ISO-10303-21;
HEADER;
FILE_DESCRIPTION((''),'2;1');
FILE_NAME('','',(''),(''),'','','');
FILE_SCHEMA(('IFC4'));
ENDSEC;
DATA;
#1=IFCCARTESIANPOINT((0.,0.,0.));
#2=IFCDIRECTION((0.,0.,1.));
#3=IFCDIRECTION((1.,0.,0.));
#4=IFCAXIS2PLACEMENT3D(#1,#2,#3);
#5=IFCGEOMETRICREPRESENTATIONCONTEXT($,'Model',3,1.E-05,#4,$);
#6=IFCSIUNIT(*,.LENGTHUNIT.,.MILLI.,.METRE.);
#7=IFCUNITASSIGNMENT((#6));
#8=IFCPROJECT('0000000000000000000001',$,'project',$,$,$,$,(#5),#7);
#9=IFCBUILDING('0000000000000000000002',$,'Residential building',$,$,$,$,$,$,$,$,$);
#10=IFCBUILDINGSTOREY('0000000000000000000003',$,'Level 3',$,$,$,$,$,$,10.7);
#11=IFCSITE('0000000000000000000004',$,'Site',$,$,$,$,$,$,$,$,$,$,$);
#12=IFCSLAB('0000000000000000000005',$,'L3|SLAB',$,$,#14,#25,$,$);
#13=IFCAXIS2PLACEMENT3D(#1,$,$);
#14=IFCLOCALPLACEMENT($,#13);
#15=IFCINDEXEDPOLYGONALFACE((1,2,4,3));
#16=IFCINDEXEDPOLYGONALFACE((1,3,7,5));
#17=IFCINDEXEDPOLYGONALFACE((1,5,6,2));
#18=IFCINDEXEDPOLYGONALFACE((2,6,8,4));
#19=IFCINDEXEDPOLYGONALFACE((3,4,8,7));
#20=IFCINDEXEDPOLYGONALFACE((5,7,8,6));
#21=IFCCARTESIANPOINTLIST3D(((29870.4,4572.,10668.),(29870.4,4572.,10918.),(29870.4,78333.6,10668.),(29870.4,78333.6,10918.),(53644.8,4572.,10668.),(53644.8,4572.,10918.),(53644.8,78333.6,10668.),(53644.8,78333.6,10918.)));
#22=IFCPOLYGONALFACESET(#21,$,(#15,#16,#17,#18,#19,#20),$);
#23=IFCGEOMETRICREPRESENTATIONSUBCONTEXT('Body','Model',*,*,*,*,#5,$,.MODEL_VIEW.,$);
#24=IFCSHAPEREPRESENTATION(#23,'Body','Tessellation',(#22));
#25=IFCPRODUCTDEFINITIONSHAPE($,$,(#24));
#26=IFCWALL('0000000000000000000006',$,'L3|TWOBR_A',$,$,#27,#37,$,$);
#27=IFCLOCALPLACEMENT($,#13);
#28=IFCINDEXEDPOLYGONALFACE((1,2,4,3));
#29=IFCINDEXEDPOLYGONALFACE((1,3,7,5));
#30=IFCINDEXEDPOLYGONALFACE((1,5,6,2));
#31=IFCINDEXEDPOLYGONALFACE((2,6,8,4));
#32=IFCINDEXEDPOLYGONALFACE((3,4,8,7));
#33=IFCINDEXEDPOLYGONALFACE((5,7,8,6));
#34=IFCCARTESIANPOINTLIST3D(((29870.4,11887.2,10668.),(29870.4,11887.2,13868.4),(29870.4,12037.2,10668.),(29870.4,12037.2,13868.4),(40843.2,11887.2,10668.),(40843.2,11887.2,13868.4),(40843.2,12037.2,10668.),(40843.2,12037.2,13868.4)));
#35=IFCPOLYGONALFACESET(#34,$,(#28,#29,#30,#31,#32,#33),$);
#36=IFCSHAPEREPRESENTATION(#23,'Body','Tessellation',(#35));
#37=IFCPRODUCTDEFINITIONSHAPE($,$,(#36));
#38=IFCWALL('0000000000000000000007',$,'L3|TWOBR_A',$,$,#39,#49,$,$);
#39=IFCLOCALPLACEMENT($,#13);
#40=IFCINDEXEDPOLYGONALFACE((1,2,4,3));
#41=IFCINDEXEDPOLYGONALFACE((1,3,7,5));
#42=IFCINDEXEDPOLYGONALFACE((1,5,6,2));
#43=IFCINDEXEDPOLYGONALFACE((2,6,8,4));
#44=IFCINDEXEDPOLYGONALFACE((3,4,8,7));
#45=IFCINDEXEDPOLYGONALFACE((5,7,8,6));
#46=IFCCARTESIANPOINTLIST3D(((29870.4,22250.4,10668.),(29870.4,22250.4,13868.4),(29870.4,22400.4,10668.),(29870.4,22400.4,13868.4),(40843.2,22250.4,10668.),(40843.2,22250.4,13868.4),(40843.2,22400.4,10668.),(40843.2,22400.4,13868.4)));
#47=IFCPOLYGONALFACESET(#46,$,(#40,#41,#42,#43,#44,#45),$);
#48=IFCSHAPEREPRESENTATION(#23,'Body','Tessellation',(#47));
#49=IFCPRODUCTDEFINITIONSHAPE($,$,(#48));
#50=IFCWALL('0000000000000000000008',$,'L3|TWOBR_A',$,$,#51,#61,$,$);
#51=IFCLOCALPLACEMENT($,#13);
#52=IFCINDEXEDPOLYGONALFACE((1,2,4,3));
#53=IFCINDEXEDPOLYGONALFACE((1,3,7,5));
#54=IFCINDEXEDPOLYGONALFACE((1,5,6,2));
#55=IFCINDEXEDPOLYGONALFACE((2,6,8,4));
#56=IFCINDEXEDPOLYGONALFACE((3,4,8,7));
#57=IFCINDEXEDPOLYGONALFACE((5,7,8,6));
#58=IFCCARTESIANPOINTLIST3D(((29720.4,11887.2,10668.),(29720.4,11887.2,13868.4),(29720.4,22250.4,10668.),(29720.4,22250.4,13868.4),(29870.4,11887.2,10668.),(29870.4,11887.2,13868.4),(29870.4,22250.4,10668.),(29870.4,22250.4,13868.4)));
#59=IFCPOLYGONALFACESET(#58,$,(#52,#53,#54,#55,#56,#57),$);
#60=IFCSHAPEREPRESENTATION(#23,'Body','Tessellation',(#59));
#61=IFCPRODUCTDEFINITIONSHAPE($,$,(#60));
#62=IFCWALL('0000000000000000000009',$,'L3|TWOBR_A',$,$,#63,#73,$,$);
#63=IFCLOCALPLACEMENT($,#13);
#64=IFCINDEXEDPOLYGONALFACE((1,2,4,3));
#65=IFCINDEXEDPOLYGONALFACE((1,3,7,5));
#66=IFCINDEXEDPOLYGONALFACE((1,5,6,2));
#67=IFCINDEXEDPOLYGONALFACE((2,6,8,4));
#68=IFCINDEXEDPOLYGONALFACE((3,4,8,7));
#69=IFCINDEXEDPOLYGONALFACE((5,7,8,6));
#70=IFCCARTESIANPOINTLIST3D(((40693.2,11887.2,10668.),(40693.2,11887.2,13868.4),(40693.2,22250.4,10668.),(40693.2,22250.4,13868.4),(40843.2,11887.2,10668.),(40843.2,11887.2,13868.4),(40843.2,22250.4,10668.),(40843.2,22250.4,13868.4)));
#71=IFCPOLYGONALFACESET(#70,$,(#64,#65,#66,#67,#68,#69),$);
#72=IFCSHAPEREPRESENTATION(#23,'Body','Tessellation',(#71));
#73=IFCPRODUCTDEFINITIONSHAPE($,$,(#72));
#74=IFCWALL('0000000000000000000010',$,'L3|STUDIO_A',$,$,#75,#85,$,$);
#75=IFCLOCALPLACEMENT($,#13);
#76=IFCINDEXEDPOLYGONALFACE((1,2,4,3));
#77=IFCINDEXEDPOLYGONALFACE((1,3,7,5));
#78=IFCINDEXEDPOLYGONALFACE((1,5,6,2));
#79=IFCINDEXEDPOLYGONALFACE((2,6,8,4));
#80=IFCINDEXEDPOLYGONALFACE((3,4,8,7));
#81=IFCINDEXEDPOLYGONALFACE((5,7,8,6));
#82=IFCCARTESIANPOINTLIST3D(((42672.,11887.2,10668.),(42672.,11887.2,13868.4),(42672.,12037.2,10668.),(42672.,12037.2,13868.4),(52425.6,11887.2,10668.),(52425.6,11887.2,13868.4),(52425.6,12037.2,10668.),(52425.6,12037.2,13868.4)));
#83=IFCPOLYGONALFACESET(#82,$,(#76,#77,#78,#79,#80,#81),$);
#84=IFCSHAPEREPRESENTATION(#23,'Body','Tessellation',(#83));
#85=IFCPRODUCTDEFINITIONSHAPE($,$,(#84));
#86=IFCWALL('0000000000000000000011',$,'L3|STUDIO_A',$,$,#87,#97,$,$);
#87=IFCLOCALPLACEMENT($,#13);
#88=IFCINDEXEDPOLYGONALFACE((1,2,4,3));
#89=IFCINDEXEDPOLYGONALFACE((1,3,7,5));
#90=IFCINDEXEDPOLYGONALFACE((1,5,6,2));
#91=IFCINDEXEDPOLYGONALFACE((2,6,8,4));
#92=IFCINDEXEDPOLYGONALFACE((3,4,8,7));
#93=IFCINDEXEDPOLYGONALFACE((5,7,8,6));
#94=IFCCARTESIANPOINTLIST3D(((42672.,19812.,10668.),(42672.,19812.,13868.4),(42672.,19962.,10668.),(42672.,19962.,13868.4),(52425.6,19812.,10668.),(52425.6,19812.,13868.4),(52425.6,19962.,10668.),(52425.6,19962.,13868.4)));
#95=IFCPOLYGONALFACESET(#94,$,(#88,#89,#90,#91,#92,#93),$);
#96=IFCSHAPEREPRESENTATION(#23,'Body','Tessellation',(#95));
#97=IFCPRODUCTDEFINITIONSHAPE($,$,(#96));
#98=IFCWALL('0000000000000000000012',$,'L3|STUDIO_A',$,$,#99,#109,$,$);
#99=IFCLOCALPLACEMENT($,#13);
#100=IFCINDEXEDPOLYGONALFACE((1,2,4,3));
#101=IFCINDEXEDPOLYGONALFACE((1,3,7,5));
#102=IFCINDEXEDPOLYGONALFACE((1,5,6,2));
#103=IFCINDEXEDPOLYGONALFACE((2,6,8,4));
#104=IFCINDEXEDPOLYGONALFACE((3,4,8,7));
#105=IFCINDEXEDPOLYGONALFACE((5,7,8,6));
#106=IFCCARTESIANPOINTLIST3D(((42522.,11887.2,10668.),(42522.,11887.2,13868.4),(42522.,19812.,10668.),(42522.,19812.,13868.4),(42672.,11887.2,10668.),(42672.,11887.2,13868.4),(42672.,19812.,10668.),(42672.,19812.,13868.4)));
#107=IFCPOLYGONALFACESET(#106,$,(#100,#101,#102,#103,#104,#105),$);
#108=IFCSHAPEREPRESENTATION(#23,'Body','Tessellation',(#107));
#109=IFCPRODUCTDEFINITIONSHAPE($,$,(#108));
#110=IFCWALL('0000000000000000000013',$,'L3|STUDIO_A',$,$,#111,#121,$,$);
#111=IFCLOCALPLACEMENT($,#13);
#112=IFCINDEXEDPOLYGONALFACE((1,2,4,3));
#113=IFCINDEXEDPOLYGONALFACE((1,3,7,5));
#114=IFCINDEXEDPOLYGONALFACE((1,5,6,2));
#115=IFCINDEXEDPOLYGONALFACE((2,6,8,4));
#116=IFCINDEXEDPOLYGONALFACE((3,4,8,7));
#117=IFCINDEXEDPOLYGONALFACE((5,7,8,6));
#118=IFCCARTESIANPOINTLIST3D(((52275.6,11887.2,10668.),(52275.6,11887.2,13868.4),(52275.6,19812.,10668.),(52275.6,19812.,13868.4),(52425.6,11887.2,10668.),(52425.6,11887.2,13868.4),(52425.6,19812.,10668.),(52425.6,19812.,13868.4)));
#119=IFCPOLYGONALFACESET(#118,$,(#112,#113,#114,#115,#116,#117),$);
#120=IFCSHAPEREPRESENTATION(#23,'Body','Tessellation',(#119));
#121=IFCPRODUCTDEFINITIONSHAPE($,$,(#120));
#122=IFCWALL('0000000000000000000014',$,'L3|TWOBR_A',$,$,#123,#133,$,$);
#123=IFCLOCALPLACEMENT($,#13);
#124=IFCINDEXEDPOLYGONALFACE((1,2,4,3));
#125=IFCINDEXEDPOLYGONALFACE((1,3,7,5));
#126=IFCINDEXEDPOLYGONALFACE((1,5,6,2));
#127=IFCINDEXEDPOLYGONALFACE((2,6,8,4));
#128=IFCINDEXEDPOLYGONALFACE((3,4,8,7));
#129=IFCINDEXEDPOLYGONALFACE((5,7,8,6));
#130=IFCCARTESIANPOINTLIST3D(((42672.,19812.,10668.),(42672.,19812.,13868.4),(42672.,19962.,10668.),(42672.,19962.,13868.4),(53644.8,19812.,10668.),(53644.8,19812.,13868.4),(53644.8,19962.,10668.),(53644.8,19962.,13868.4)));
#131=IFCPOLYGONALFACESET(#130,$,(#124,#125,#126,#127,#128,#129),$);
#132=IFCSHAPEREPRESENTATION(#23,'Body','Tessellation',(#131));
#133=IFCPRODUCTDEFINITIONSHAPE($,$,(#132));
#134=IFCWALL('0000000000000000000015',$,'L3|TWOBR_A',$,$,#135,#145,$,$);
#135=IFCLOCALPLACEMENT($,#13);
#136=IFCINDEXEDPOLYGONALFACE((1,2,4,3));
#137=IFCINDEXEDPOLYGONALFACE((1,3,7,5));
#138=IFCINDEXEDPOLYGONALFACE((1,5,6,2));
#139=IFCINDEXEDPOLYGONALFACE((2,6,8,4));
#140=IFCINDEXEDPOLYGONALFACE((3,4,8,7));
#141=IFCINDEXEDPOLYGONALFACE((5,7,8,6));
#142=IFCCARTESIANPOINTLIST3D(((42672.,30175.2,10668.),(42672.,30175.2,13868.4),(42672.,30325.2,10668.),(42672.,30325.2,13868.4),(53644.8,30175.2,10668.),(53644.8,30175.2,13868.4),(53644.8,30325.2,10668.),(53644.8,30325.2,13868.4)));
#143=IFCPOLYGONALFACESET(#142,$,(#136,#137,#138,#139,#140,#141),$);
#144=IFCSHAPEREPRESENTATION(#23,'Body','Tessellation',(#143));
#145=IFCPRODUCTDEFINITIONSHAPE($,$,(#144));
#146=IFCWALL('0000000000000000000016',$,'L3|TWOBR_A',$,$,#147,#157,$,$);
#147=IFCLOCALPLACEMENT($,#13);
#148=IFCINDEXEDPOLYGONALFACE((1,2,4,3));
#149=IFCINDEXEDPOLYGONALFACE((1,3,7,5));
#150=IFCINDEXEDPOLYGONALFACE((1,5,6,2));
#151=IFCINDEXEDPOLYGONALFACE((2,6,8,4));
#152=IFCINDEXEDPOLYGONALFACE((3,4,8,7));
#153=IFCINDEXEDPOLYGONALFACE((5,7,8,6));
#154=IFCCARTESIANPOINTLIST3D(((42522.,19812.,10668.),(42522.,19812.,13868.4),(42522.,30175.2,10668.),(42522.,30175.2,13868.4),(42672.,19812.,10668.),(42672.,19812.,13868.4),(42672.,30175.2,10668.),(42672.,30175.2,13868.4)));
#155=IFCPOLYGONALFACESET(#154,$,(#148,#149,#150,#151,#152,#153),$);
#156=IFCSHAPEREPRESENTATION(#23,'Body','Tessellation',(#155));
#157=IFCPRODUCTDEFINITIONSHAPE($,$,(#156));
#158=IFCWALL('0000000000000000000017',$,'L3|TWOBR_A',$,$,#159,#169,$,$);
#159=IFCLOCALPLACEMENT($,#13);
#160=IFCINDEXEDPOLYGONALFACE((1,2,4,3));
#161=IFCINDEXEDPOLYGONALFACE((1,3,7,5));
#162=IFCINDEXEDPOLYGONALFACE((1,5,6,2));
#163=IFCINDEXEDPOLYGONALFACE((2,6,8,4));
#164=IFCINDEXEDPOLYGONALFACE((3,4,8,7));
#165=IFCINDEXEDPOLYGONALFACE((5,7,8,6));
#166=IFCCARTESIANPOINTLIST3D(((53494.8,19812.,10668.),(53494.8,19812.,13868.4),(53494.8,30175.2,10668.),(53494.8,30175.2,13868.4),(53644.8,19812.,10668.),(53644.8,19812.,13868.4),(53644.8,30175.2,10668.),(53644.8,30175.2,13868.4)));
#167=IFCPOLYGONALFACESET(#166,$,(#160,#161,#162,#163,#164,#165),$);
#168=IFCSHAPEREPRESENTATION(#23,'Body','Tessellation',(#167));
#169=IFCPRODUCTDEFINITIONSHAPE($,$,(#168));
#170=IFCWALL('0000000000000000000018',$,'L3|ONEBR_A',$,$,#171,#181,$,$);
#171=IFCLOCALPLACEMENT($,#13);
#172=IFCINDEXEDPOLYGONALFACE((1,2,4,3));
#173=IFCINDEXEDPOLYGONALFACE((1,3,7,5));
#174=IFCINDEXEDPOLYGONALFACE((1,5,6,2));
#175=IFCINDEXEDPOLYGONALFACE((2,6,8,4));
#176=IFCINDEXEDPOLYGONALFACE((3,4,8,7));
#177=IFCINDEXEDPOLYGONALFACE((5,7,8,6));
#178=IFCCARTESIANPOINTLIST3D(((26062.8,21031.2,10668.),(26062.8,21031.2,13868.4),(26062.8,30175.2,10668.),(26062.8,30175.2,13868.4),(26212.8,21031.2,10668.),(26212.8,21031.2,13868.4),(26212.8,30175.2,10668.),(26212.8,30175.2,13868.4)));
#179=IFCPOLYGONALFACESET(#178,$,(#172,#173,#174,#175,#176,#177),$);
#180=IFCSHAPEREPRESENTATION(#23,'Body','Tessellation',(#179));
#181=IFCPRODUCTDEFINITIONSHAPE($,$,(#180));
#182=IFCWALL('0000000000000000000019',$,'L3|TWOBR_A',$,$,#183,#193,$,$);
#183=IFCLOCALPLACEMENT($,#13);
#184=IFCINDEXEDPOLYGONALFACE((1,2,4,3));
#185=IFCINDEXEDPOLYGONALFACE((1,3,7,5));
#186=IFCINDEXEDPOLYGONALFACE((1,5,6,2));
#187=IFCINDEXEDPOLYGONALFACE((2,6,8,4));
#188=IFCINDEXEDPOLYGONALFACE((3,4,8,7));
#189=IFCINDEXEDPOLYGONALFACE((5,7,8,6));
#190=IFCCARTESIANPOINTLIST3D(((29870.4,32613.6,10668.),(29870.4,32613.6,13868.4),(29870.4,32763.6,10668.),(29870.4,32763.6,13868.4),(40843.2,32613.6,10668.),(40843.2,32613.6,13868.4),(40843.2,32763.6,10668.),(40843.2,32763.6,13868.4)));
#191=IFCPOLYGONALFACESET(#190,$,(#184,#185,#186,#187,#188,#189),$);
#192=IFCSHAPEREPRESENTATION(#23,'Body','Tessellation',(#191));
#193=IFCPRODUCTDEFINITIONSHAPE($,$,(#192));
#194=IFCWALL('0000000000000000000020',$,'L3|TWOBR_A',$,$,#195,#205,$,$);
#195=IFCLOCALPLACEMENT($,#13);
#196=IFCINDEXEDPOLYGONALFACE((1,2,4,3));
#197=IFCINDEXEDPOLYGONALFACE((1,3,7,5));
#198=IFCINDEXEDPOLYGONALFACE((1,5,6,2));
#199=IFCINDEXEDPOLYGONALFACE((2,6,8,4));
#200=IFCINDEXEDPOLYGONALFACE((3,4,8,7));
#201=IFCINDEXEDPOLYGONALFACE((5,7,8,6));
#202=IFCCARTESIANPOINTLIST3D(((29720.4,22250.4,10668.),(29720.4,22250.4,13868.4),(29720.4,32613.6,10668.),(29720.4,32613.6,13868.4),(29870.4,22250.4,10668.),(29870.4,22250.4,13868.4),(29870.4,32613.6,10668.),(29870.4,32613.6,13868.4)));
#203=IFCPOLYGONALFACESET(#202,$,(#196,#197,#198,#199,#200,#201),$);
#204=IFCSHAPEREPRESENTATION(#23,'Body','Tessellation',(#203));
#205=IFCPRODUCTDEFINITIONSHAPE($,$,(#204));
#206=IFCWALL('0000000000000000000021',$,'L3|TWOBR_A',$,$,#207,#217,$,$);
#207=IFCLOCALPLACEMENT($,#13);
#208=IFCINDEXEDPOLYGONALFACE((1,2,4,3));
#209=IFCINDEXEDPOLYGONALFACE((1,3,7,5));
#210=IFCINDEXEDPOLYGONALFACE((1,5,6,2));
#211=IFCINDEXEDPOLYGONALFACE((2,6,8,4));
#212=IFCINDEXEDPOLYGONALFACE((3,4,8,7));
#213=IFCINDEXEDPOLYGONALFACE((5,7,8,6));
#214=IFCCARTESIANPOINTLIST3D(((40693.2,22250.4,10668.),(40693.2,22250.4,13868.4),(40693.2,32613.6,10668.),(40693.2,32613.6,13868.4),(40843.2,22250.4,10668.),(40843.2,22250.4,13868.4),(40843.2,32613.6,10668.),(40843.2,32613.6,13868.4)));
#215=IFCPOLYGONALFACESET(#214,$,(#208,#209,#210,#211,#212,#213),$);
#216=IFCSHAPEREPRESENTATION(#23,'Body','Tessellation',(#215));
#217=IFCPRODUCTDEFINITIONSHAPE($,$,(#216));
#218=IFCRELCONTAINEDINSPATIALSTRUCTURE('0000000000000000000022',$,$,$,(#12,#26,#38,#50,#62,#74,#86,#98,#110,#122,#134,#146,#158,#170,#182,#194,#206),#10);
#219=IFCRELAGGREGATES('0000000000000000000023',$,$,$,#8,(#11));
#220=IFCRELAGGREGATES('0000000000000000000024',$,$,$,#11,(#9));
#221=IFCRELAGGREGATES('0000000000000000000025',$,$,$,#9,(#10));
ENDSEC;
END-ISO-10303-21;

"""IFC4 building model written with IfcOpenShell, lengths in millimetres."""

from ifc_helpers import new_model, si_unit, frame, origin_with_axes, place, context, subcontext, project, spatial, indexed_curve, outline, extrude, element, save


model = new_model("IFC4")

# Units and contexts
model_context = context("Model", 3, precision=1e-05, world=origin_with_axes())
body_context = subcontext(model_context, "Body", "Model", "MODEL_VIEW")
ifc_project = project(units=[si_unit("LENGTHUNIT", "METRE", prefix="MILLI")], contexts=[model_context])

# Site, building, storey
site = spatial("IfcSite", under=ifc_project, Name="Site")
building = spatial("IfcBuilding", under=site, Name="Residential building")
storey = spatial("IfcBuildingStorey", under=building, Name="Level 3", Elevation=10.7)

# Slab
slab_placement = place(None, frame((29870.4, 4572.0, 10668.0), z_axis=(0.0, 0.0, 1.0), x_axis=(1.0, 0.0, 0.0)))
element("IfcSlab", 1, at=slab_placement, inside=storey, Name="L3|SLAB", context=body_context, shape_type="SweptSolid", body=[
    extrude(outline(indexed_curve([(0.0, 0.0), (23774.4, 0.0), (23774.4, 73761.6), (0.0, 73761.6), (0.0, 0.0)])), None, (0.0, 0.0, 1.0), 250.0),
])

# Walls
for number, where, z_axis, x_axis, name in (
    (2, (29870.4, 11887.2, 10668.0), (0.0, 0.0, 1.0), (1.0, 0.0, 0.0), "L3|TWOBR_A"),
    (3, (29870.4, 22250.4, 10668.0), (0.0, 0.0, 1.0), (1.0, 0.0, 0.0), "L3|TWOBR_A"),
):
    element("IfcWall", number, at=place(None, frame(where, z_axis=z_axis, x_axis=x_axis)), inside=storey, Name=name, context=body_context, shape_type="SweptSolid", body=[
        extrude(outline(indexed_curve([(0.0, 0.0), (0.0, 150.0), (10972.8, 150.0), (10972.8, 0.0), (0.0, 0.0)], self_intersect=False)), origin_with_axes(), (0.0, 0.0, 1.0), 3200.4),
    ])
for number, where, z_axis, x_axis, name in (
    (4, (29870.4, 11887.2, 10668.0), (0.0, 0.0, 1.0), (0.0, 1.0, 0.0), "L3|TWOBR_A"),
    (5, (40843.2, 11887.2, 10668.0), (0.0, 0.0, 1.0), (0.0, 1.0, 0.0), "L3|TWOBR_A"),
):
    element("IfcWall", number, at=place(None, frame(where, z_axis=z_axis, x_axis=x_axis)), inside=storey, Name=name, context=body_context, shape_type="SweptSolid", body=[
        extrude(outline(indexed_curve([(0.0, 0.0), (0.0, 150.0), (10363.2, 150.0), (10363.2, 0.0), (0.0, 0.0)], self_intersect=False)), origin_with_axes(), (0.0, 0.0, 1.0), 3200.4),
    ])
for number, where, z_axis, x_axis, name in (
    (6, (42672.0, 11887.2, 10668.0), (0.0, 0.0, 1.0), (1.0, 0.0, 0.0), "L3|STUDIO_A"),
    (7, (42672.0, 19812.0, 10668.0), (0.0, 0.0, 1.0), (1.0, 0.0, 0.0), "L3|STUDIO_A"),
):
    element("IfcWall", number, at=place(None, frame(where, z_axis=z_axis, x_axis=x_axis)), inside=storey, Name=name, context=body_context, shape_type="SweptSolid", body=[
        extrude(outline(indexed_curve([(0.0, 0.0), (0.0, 150.0), (9753.6, 150.0), (9753.6, 0.0), (0.0, 0.0)], self_intersect=False)), origin_with_axes(), (0.0, 0.0, 1.0), 3200.4),
    ])
for number, where, z_axis, x_axis, name in (
    (8, (42672.0, 11887.2, 10668.0), (0.0, 0.0, 1.0), (0.0, 1.0, 0.0), "L3|STUDIO_A"),
    (9, (52425.6, 11887.2, 10668.0), (0.0, 0.0, 1.0), (0.0, 1.0, 0.0), "L3|STUDIO_A"),
):
    element("IfcWall", number, at=place(None, frame(where, z_axis=z_axis, x_axis=x_axis)), inside=storey, Name=name, context=body_context, shape_type="SweptSolid", body=[
        extrude(outline(indexed_curve([(0.0, 0.0), (0.0, 150.0), (7924.8, 150.0), (7924.8, 0.0), (0.0, 0.0)], self_intersect=False)), origin_with_axes(), (0.0, 0.0, 1.0), 3200.4),
    ])
for number, where, z_axis, x_axis, name in (
    (10, (42672.0, 19812.0, 10668.0), (0.0, 0.0, 1.0), (1.0, 0.0, 0.0), "L3|TWOBR_A"),
    (11, (42672.0, 30175.2, 10668.0), (0.0, 0.0, 1.0), (1.0, 0.0, 0.0), "L3|TWOBR_A"),
):
    element("IfcWall", number, at=place(None, frame(where, z_axis=z_axis, x_axis=x_axis)), inside=storey, Name=name, context=body_context, shape_type="SweptSolid", body=[
        extrude(outline(indexed_curve([(0.0, 0.0), (0.0, 150.0), (10972.8, 150.0), (10972.8, 0.0), (0.0, 0.0)], self_intersect=False)), origin_with_axes(), (0.0, 0.0, 1.0), 3200.4),
    ])
for number, where, z_axis, x_axis, name in (
    (12, (42672.0, 19812.0, 10668.0), (0.0, 0.0, 1.0), (0.0, 1.0, 0.0), "L3|TWOBR_A"),
    (13, (53644.8, 19812.0, 10668.0), (0.0, 0.0, 1.0), (0.0, 1.0, 0.0), "L3|TWOBR_A"),
):
    element("IfcWall", number, at=place(None, frame(where, z_axis=z_axis, x_axis=x_axis)), inside=storey, Name=name, context=body_context, shape_type="SweptSolid", body=[
        extrude(outline(indexed_curve([(0.0, 0.0), (0.0, 150.0), (10363.2, 150.0), (10363.2, 0.0), (0.0, 0.0)], self_intersect=False)), origin_with_axes(), (0.0, 0.0, 1.0), 3200.4),
    ])
wall_1_placement = place(None, frame((26212.8, 21031.2, 10668.0), z_axis=(0.0, 0.0, 1.0), x_axis=(0.0, 1.0, 0.0)))
element("IfcWall", 14, at=wall_1_placement, inside=storey, Name="L3|ONEBR_A", context=body_context, shape_type="SweptSolid", body=[
    extrude(outline(indexed_curve([(0.0, 0.0), (0.0, 150.0), (9144.0, 150.0), (9144.0, 0.0), (0.0, 0.0)], self_intersect=False)), origin_with_axes(), (0.0, 0.0, 1.0), 3200.4),
])
for number, where, z_axis, x_axis, name in (
    (15, (29870.4, 32613.6, 10668.0), (0.0, 0.0, 1.0), (1.0, 0.0, 0.0), "L3|TWOBR_A"),
):
    element("IfcWall", number, at=place(None, frame(where, z_axis=z_axis, x_axis=x_axis)), inside=storey, Name=name, context=body_context, shape_type="SweptSolid", body=[
        extrude(outline(indexed_curve([(0.0, 0.0), (0.0, 150.0), (10972.8, 150.0), (10972.8, 0.0), (0.0, 0.0)], self_intersect=False)), origin_with_axes(), (0.0, 0.0, 1.0), 3200.4),
    ])
for number, where, z_axis, x_axis, name in (
    (16, (29870.4, 22250.4, 10668.0), (0.0, 0.0, 1.0), (0.0, 1.0, 0.0), "L3|TWOBR_A"),
    (17, (40843.2, 22250.4, 10668.0), (0.0, 0.0, 1.0), (0.0, 1.0, 0.0), "L3|TWOBR_A"),
):
    element("IfcWall", number, at=place(None, frame(where, z_axis=z_axis, x_axis=x_axis)), inside=storey, Name=name, context=body_context, shape_type="SweptSolid", body=[
        extrude(outline(indexed_curve([(0.0, 0.0), (0.0, 150.0), (10363.2, 150.0), (10363.2, 0.0), (0.0, 0.0)], self_intersect=False)), origin_with_axes(), (0.0, 0.0, 1.0), 3200.4),
    ])

save(model, "model.ifc")
